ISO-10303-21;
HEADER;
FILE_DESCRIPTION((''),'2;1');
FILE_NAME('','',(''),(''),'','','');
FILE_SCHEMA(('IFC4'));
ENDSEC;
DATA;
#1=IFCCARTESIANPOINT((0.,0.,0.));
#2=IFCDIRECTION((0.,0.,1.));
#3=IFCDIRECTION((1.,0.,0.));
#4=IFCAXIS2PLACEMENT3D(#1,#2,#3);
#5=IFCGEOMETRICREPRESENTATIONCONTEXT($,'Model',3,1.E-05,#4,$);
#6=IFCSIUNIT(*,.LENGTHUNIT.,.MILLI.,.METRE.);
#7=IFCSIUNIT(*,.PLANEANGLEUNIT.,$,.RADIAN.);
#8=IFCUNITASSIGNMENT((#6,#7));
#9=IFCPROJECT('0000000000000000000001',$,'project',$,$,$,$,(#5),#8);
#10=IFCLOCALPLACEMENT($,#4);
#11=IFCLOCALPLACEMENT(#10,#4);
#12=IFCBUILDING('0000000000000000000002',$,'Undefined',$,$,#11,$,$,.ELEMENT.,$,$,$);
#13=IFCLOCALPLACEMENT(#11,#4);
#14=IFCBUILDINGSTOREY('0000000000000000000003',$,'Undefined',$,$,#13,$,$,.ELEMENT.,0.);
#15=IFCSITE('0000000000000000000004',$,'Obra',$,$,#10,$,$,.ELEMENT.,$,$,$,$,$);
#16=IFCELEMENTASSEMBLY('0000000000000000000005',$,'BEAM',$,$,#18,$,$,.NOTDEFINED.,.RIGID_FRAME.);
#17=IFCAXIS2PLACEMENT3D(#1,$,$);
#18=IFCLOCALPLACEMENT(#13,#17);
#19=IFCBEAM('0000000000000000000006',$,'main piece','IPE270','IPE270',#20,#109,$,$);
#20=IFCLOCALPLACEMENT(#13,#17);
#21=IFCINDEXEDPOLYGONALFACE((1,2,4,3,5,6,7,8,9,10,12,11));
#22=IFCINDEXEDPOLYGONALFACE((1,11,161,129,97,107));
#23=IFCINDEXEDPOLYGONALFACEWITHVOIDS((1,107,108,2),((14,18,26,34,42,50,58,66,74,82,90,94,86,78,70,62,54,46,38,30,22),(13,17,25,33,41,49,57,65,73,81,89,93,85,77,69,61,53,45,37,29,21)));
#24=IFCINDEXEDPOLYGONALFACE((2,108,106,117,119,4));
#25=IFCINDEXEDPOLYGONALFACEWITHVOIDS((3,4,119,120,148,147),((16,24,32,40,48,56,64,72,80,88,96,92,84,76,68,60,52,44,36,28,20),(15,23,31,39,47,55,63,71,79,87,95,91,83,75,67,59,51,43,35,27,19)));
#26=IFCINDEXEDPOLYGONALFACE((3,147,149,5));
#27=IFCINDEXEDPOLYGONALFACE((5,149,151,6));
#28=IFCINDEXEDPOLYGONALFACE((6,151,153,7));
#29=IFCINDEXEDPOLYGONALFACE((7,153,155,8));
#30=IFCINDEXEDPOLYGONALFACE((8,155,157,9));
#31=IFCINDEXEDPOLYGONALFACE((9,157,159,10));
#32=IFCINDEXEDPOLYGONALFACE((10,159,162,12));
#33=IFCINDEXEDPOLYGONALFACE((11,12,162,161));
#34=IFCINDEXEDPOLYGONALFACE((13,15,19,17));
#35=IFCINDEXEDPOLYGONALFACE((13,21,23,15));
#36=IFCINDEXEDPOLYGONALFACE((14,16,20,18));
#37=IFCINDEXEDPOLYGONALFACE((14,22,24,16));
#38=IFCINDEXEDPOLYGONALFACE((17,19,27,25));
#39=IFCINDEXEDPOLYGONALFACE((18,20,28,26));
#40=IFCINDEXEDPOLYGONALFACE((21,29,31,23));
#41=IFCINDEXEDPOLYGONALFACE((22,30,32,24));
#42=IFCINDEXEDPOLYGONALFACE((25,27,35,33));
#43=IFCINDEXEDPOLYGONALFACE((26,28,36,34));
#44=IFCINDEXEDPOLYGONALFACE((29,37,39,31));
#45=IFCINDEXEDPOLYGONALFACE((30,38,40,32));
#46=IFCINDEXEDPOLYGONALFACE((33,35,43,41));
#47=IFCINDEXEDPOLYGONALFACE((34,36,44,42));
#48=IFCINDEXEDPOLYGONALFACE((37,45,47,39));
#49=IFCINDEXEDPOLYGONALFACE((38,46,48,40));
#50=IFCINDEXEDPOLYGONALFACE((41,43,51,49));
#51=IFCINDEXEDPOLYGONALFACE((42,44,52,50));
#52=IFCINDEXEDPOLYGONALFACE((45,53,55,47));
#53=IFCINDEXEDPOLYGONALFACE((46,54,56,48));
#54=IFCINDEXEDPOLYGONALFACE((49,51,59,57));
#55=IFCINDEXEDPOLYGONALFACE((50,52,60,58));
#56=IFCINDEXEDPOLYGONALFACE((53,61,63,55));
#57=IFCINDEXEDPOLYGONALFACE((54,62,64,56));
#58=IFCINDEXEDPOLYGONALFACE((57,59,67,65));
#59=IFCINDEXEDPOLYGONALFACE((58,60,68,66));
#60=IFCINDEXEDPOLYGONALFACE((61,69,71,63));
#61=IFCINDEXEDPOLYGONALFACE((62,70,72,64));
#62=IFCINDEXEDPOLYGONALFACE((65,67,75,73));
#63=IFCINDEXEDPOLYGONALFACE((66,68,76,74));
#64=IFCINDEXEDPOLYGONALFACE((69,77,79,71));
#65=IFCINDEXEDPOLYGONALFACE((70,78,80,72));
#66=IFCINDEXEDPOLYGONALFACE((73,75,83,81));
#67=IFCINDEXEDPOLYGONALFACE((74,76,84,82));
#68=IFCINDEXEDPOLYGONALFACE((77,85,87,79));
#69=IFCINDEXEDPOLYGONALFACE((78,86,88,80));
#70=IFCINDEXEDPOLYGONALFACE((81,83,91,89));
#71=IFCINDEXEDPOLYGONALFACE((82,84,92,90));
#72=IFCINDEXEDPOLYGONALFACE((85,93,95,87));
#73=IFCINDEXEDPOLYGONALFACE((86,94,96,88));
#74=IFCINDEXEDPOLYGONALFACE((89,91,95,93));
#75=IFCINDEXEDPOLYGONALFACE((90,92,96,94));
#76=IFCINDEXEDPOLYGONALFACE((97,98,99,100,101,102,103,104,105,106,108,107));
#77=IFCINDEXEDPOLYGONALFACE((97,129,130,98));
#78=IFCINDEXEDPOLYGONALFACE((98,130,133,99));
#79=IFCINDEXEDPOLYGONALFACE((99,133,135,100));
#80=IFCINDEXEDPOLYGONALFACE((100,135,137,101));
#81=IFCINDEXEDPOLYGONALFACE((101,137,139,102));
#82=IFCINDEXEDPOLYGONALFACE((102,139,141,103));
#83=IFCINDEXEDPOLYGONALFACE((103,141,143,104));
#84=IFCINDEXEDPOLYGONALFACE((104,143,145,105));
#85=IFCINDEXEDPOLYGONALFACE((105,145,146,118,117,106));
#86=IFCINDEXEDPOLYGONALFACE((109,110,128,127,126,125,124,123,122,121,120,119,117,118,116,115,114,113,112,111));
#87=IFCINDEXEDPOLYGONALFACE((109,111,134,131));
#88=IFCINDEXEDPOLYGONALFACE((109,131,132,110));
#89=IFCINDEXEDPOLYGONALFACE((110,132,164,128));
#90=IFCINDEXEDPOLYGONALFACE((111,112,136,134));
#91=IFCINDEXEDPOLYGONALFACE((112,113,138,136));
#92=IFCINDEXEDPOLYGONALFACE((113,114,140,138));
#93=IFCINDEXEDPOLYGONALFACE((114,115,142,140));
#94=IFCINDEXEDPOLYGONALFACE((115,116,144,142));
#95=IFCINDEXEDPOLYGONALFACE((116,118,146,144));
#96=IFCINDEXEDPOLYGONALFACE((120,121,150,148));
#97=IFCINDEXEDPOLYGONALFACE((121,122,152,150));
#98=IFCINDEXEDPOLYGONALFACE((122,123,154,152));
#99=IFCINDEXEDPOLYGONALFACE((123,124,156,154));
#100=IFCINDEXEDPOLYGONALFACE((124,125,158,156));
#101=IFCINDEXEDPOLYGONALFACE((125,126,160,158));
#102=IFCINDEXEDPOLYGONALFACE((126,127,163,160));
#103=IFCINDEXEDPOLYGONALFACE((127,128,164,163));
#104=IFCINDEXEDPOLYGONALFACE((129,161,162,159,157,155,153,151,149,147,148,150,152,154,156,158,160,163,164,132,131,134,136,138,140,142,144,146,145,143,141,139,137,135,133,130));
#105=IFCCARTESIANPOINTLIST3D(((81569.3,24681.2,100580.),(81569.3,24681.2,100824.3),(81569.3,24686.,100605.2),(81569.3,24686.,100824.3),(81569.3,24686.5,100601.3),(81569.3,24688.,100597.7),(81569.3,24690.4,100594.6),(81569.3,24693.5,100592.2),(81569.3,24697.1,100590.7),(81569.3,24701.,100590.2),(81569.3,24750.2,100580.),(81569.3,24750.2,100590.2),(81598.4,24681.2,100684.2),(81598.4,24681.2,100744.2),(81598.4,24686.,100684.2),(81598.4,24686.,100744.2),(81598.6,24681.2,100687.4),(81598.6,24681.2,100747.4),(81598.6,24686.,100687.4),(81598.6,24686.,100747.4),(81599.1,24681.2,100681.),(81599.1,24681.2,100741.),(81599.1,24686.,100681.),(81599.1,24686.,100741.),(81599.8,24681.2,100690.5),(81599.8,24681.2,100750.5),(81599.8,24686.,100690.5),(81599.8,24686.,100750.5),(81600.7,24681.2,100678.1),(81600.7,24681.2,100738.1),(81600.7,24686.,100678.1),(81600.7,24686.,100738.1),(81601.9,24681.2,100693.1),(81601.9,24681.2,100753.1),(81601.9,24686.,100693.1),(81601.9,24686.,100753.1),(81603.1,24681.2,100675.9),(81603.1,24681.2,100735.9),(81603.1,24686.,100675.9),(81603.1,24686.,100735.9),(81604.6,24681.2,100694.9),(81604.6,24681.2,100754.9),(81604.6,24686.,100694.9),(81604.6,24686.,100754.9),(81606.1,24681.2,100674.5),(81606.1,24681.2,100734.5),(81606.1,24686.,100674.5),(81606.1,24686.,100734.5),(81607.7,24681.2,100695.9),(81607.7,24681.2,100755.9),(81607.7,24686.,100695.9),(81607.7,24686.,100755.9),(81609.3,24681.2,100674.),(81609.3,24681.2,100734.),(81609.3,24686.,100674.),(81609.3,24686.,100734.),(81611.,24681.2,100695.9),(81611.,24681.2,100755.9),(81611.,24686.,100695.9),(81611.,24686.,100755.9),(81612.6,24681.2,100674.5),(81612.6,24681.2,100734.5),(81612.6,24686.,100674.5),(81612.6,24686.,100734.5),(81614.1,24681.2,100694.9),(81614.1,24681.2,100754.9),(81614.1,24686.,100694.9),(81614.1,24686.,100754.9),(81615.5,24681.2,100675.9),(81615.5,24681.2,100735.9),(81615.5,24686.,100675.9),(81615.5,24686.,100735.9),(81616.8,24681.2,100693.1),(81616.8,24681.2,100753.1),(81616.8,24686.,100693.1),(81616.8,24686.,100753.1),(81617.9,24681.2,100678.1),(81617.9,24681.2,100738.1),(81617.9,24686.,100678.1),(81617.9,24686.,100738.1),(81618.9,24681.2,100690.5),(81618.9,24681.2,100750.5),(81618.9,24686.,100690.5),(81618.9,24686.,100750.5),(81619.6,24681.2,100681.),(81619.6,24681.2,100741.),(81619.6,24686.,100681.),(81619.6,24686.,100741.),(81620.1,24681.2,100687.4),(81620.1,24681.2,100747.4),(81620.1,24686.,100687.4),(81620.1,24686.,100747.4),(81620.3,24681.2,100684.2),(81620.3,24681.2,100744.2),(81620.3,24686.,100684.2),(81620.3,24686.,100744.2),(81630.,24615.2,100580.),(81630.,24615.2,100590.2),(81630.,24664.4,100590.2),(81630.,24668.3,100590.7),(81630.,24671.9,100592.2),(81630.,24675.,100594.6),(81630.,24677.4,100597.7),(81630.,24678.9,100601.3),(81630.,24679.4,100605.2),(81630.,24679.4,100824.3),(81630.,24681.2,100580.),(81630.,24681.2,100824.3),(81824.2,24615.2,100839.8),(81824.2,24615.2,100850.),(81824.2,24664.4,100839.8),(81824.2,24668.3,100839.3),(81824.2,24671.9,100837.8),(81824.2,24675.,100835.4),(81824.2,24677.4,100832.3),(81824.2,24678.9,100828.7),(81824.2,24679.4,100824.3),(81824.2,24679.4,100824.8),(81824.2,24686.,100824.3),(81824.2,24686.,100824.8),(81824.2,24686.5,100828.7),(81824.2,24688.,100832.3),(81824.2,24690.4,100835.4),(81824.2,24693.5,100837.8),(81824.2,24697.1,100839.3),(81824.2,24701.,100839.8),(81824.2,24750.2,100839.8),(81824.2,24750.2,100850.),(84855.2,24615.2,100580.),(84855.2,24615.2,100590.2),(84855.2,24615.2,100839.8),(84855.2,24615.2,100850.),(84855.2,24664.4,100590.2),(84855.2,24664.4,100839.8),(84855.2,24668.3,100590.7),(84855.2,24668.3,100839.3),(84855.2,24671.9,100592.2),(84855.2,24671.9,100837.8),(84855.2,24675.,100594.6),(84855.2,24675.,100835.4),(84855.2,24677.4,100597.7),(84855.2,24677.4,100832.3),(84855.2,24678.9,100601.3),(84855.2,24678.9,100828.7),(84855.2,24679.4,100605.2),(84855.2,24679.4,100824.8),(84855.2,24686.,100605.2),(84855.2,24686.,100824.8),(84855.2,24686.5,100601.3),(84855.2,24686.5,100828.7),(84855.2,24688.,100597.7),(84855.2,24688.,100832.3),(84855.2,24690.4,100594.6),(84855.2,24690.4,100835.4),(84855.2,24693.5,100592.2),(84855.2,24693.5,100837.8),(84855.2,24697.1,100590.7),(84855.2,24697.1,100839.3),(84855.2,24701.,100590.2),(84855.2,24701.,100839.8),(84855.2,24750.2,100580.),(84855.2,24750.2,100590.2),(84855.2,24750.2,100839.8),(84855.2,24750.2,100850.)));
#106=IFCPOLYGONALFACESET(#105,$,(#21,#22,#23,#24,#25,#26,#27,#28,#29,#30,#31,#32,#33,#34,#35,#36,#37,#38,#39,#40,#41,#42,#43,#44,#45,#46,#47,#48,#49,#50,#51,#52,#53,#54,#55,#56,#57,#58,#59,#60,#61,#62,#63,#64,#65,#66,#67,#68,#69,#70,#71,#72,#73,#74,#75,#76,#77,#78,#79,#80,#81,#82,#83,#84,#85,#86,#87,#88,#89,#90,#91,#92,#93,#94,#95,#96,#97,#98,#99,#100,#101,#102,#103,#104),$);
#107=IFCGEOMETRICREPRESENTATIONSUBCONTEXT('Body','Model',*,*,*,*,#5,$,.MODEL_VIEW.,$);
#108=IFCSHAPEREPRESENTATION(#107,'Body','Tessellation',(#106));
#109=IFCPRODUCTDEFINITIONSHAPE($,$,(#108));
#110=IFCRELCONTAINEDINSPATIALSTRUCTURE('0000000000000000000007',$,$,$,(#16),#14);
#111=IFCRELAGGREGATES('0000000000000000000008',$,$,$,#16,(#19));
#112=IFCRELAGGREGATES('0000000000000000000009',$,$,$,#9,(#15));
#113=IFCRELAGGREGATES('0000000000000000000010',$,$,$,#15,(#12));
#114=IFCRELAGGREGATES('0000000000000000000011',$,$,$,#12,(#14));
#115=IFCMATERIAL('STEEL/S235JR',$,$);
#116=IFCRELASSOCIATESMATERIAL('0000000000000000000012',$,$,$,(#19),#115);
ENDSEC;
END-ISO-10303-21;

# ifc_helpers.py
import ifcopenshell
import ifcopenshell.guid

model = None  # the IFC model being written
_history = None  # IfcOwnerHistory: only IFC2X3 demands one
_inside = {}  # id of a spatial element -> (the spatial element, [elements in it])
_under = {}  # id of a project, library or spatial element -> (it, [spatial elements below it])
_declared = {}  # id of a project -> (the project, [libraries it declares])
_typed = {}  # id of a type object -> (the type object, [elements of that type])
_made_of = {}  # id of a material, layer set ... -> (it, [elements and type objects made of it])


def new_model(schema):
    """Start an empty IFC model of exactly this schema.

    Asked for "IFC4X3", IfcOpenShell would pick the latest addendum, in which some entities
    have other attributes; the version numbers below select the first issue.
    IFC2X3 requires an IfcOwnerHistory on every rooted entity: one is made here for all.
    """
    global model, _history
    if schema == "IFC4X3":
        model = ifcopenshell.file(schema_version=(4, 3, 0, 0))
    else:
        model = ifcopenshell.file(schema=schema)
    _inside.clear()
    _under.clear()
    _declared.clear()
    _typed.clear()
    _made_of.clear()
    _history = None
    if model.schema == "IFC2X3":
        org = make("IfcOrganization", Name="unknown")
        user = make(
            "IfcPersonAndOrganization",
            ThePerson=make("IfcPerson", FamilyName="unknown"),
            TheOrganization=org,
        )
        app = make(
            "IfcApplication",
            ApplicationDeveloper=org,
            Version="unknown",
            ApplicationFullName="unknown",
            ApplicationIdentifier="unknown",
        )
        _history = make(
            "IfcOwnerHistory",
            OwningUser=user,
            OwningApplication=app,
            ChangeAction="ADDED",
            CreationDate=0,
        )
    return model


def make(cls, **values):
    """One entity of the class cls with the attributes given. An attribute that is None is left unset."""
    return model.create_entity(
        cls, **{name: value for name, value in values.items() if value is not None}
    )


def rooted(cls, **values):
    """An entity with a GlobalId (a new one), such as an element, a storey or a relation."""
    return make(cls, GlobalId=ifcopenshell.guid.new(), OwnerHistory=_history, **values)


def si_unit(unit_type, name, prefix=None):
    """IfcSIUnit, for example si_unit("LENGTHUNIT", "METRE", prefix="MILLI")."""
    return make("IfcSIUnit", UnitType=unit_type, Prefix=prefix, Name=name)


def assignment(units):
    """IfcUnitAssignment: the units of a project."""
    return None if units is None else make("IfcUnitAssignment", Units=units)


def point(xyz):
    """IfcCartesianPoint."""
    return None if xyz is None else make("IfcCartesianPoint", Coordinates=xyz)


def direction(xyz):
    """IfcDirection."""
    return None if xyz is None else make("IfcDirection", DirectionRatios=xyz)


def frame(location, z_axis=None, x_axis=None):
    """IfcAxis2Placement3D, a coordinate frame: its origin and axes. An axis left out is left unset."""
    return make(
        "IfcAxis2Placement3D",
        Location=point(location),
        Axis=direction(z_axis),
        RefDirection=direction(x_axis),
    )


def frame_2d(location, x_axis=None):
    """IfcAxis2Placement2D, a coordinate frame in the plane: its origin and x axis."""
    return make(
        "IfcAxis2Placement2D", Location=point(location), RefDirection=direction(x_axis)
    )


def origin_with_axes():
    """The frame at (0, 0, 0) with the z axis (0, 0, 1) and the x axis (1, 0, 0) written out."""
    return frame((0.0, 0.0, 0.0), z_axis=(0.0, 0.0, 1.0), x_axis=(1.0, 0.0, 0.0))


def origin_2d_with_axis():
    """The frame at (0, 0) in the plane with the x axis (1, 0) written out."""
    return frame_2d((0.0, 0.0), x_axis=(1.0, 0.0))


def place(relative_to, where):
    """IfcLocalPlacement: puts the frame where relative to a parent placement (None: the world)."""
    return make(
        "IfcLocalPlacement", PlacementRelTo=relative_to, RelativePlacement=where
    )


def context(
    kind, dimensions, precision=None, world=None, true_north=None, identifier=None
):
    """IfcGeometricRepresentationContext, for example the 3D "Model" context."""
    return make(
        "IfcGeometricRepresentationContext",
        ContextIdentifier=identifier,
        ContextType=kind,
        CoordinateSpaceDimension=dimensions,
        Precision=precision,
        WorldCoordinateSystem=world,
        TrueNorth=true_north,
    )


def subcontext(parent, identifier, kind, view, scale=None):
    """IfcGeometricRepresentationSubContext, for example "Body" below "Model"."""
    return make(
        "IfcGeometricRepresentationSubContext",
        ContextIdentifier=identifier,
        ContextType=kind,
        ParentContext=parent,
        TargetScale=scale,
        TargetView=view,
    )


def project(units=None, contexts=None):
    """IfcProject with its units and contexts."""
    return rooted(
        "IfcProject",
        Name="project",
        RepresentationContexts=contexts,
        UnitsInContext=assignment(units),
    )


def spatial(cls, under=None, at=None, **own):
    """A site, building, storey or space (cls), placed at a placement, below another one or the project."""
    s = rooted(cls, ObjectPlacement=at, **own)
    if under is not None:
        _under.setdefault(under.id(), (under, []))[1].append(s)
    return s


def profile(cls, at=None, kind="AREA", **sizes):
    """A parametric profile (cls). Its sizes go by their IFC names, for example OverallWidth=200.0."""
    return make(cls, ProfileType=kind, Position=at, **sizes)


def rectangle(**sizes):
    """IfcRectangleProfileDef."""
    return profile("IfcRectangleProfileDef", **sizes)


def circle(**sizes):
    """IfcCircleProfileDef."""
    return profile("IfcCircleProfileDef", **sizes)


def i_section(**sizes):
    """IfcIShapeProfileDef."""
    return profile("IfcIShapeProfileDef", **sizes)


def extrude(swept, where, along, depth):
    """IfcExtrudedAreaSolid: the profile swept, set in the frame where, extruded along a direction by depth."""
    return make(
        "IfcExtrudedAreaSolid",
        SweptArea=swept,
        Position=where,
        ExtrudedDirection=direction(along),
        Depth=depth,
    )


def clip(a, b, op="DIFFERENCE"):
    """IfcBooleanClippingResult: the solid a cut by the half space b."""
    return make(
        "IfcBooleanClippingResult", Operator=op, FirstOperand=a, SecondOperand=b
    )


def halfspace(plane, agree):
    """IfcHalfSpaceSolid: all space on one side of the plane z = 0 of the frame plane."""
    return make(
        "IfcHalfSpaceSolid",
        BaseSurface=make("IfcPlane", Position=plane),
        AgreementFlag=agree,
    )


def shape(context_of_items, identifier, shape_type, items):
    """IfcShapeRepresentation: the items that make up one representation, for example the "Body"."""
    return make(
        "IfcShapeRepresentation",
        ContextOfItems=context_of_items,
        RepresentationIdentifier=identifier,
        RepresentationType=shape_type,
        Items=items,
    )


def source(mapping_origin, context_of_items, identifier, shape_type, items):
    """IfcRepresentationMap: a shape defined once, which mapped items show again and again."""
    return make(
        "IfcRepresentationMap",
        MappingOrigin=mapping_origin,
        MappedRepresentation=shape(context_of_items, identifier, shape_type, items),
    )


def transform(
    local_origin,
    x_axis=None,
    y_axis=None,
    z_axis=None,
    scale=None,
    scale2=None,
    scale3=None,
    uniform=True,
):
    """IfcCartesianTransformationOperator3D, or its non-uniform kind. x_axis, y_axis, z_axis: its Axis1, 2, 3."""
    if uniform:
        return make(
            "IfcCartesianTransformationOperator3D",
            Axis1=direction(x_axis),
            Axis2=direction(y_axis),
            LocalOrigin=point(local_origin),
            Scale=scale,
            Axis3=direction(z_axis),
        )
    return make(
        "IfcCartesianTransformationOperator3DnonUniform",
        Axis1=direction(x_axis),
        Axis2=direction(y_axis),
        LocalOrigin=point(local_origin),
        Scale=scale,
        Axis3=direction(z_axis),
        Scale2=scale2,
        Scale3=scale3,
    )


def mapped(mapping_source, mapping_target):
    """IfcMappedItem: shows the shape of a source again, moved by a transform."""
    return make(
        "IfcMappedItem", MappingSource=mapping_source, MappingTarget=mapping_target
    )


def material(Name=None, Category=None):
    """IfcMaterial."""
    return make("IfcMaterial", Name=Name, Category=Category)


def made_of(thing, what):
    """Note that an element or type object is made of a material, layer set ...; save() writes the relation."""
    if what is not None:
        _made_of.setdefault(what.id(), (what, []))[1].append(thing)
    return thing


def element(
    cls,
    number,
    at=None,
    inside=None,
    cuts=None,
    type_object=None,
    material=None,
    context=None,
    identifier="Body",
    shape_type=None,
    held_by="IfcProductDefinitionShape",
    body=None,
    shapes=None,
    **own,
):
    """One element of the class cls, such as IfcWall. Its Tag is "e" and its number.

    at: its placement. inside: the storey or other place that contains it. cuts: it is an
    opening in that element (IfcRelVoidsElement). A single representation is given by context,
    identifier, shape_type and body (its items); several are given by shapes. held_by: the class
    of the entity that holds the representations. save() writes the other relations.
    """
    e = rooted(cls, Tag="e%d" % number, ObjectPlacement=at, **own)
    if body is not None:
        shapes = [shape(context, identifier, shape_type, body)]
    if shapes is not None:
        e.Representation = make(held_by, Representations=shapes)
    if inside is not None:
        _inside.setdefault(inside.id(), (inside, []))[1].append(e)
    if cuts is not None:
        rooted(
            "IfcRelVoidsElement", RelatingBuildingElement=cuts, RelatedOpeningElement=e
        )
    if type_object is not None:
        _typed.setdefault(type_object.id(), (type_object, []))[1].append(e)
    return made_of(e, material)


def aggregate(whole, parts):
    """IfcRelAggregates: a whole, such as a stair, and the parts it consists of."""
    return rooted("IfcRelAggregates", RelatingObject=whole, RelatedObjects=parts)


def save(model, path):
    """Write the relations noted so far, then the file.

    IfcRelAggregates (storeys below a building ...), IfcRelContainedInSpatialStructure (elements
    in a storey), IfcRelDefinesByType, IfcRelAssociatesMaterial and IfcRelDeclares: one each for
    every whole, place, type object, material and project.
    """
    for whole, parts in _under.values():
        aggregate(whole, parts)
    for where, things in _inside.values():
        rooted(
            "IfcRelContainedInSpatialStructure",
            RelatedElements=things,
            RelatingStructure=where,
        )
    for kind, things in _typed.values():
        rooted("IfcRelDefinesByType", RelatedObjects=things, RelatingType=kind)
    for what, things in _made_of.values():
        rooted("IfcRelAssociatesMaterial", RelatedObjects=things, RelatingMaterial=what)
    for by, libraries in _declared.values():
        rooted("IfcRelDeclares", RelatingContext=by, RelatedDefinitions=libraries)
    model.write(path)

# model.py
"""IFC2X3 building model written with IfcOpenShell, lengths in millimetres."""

from ifc_helpers import new_model, si_unit, frame, origin_with_axes, origin_2d_with_axis, place, context, subcontext, project, spatial, rectangle, circle, i_section, extrude, clip, halfspace, source, transform, mapped, material, element, aggregate, save


model = new_model("IFC2X3")

# Units and contexts
model_context = context("Model", 3, precision=1e-05, world=origin_with_axes())
body_context = subcontext(model_context, "Body", "Model", "MODEL_VIEW")
ifc_project = project(units=[si_unit("LENGTHUNIT", "METRE", prefix="MILLI"), si_unit("PLANEANGLEUNIT", "RADIAN")], contexts=[model_context])

# Site, building, storey
site_placement = place(None, origin_with_axes())
site = spatial("IfcSite", under=ifc_project, at=site_placement, Name="Obra", CompositionType="ELEMENT")
building_placement = place(site_placement, origin_with_axes())
building = spatial("IfcBuilding", under=site, at=building_placement, Name="Undefined", CompositionType="ELEMENT")
storey_placement = place(building_placement, origin_with_axes())
storey = spatial("IfcBuildingStorey", under=building, at=storey_placement, Name="Undefined", CompositionType="ELEMENT", Elevation=0.0)

# Shared definitions
ifc_material = material(Name="STEEL/S235JR")

# Element assembly, beam, openings
shared_shape = source(origin_with_axes(), body_context, "Body", "SweptSolid", [
    extrude(circle(Radius=11.0, at=origin_2d_with_axis()), frame((0.0, -3.4, 0.0), z_axis=(0.0, 1.0, 0.0), x_axis=(1.0, 0.0, 0.0)), (0.0, 0.0, 1.0), 6.8),
])
assembly_1_placement = place(storey_placement, origin_with_axes())
assembly_1 = element("IfcElementAssembly", 1, at=assembly_1_placement, inside=storey, Name="BEAM", AssemblyPlace="NOTDEFINED", PredefinedType="RIGID_FRAME")
beam_1_placement = place(assembly_1_placement, frame((81655.0, 24682.7, 100715.0), z_axis=(0.0, 0.0, 1.0), x_axis=(1.0, 0.000001, 0.0)))
beam_1 = element("IfcBeam", 2, at=beam_1_placement, material=ifc_material, Name="main piece", Description="IPE270", ObjectType="IPE270", context=body_context, shape_type="Clipping", body=[
    clip(extrude(i_section(OverallWidth=135.0, OverallDepth=270.0, WebThickness=6.6, FlangeThickness=10.2, FilletRadius=15.0, at=origin_2d_with_axis()), frame((3200.1, 0.0, 0.0), z_axis=(-1.0, 0.0, 0.0), x_axis=(0.0, -1.0, 0.0)), (0.0, 0.0, 1.0), 3285.8), halfspace(frame((-85.7, 0.0, -235.0), z_axis=(1.0, 0.0, 0.0), x_axis=(0.0, -1.0, 0.0)), True)),
])
opening_1_placement = place(assembly_1_placement, frame((81655.0, 24682.7, 100715.0), z_axis=(0.0, 0.0, 1.0), x_axis=(1.0, 0.000001, 0.0)))
element("IfcOpeningElement", 3, at=opening_1_placement, cuts=beam_1, ObjectType="Recess", context=body_context, shape_type="SweptSolid", body=[
    extrude(rectangle(XDim=72.8, YDim=300.0, at=origin_2d_with_axis()), frame((-61.4, -151.5, 124.3), z_axis=(0.0, 0.0, -1.0), x_axis=(1.0, 0.0, 0.0)), (0.0, 0.0, 1.0), 278.6),
])
opening_2_placement = place(assembly_1_placement, frame((81655.0, 24682.7, 100715.0), z_axis=(0.0, 0.0, 1.0), x_axis=(1.0, 0.000001, 0.0)))
element("IfcOpeningElement", 4, at=opening_2_placement, cuts=beam_1, ObjectType="Recess", context=body_context, shape_type="SweptSolid", body=[
    extrude(rectangle(XDim=26.7, YDim=266.9, at=origin_2d_with_axis()), frame((35.8, -68.5, 122.7), z_axis=(0.0, 1.0, 0.0), x_axis=(0.0, 0.0, -1.0)), (0.0, 0.0, 1.0), 137.0),
])
opening_3_placement = place(assembly_1_placement, frame((81569.3, 24682.7, 100850.0), z_axis=(1.0, 0.000001, 0.0), x_axis=(0.0, 0.0, -1.0)))
element("IfcOpeningElement", 5, at=opening_3_placement, cuts=beam_1, ObjectType="Opening", context=body_context, shape_type="MappedRepresentation", body=[
    mapped(shared_shape, transform((105.0, 0.0, 40.0))),
    mapped(shared_shape, transform((165.0, 0.0, 40.0))),
])
aggregate(assembly_1, [beam_1])

save(model, "model.ifc")
